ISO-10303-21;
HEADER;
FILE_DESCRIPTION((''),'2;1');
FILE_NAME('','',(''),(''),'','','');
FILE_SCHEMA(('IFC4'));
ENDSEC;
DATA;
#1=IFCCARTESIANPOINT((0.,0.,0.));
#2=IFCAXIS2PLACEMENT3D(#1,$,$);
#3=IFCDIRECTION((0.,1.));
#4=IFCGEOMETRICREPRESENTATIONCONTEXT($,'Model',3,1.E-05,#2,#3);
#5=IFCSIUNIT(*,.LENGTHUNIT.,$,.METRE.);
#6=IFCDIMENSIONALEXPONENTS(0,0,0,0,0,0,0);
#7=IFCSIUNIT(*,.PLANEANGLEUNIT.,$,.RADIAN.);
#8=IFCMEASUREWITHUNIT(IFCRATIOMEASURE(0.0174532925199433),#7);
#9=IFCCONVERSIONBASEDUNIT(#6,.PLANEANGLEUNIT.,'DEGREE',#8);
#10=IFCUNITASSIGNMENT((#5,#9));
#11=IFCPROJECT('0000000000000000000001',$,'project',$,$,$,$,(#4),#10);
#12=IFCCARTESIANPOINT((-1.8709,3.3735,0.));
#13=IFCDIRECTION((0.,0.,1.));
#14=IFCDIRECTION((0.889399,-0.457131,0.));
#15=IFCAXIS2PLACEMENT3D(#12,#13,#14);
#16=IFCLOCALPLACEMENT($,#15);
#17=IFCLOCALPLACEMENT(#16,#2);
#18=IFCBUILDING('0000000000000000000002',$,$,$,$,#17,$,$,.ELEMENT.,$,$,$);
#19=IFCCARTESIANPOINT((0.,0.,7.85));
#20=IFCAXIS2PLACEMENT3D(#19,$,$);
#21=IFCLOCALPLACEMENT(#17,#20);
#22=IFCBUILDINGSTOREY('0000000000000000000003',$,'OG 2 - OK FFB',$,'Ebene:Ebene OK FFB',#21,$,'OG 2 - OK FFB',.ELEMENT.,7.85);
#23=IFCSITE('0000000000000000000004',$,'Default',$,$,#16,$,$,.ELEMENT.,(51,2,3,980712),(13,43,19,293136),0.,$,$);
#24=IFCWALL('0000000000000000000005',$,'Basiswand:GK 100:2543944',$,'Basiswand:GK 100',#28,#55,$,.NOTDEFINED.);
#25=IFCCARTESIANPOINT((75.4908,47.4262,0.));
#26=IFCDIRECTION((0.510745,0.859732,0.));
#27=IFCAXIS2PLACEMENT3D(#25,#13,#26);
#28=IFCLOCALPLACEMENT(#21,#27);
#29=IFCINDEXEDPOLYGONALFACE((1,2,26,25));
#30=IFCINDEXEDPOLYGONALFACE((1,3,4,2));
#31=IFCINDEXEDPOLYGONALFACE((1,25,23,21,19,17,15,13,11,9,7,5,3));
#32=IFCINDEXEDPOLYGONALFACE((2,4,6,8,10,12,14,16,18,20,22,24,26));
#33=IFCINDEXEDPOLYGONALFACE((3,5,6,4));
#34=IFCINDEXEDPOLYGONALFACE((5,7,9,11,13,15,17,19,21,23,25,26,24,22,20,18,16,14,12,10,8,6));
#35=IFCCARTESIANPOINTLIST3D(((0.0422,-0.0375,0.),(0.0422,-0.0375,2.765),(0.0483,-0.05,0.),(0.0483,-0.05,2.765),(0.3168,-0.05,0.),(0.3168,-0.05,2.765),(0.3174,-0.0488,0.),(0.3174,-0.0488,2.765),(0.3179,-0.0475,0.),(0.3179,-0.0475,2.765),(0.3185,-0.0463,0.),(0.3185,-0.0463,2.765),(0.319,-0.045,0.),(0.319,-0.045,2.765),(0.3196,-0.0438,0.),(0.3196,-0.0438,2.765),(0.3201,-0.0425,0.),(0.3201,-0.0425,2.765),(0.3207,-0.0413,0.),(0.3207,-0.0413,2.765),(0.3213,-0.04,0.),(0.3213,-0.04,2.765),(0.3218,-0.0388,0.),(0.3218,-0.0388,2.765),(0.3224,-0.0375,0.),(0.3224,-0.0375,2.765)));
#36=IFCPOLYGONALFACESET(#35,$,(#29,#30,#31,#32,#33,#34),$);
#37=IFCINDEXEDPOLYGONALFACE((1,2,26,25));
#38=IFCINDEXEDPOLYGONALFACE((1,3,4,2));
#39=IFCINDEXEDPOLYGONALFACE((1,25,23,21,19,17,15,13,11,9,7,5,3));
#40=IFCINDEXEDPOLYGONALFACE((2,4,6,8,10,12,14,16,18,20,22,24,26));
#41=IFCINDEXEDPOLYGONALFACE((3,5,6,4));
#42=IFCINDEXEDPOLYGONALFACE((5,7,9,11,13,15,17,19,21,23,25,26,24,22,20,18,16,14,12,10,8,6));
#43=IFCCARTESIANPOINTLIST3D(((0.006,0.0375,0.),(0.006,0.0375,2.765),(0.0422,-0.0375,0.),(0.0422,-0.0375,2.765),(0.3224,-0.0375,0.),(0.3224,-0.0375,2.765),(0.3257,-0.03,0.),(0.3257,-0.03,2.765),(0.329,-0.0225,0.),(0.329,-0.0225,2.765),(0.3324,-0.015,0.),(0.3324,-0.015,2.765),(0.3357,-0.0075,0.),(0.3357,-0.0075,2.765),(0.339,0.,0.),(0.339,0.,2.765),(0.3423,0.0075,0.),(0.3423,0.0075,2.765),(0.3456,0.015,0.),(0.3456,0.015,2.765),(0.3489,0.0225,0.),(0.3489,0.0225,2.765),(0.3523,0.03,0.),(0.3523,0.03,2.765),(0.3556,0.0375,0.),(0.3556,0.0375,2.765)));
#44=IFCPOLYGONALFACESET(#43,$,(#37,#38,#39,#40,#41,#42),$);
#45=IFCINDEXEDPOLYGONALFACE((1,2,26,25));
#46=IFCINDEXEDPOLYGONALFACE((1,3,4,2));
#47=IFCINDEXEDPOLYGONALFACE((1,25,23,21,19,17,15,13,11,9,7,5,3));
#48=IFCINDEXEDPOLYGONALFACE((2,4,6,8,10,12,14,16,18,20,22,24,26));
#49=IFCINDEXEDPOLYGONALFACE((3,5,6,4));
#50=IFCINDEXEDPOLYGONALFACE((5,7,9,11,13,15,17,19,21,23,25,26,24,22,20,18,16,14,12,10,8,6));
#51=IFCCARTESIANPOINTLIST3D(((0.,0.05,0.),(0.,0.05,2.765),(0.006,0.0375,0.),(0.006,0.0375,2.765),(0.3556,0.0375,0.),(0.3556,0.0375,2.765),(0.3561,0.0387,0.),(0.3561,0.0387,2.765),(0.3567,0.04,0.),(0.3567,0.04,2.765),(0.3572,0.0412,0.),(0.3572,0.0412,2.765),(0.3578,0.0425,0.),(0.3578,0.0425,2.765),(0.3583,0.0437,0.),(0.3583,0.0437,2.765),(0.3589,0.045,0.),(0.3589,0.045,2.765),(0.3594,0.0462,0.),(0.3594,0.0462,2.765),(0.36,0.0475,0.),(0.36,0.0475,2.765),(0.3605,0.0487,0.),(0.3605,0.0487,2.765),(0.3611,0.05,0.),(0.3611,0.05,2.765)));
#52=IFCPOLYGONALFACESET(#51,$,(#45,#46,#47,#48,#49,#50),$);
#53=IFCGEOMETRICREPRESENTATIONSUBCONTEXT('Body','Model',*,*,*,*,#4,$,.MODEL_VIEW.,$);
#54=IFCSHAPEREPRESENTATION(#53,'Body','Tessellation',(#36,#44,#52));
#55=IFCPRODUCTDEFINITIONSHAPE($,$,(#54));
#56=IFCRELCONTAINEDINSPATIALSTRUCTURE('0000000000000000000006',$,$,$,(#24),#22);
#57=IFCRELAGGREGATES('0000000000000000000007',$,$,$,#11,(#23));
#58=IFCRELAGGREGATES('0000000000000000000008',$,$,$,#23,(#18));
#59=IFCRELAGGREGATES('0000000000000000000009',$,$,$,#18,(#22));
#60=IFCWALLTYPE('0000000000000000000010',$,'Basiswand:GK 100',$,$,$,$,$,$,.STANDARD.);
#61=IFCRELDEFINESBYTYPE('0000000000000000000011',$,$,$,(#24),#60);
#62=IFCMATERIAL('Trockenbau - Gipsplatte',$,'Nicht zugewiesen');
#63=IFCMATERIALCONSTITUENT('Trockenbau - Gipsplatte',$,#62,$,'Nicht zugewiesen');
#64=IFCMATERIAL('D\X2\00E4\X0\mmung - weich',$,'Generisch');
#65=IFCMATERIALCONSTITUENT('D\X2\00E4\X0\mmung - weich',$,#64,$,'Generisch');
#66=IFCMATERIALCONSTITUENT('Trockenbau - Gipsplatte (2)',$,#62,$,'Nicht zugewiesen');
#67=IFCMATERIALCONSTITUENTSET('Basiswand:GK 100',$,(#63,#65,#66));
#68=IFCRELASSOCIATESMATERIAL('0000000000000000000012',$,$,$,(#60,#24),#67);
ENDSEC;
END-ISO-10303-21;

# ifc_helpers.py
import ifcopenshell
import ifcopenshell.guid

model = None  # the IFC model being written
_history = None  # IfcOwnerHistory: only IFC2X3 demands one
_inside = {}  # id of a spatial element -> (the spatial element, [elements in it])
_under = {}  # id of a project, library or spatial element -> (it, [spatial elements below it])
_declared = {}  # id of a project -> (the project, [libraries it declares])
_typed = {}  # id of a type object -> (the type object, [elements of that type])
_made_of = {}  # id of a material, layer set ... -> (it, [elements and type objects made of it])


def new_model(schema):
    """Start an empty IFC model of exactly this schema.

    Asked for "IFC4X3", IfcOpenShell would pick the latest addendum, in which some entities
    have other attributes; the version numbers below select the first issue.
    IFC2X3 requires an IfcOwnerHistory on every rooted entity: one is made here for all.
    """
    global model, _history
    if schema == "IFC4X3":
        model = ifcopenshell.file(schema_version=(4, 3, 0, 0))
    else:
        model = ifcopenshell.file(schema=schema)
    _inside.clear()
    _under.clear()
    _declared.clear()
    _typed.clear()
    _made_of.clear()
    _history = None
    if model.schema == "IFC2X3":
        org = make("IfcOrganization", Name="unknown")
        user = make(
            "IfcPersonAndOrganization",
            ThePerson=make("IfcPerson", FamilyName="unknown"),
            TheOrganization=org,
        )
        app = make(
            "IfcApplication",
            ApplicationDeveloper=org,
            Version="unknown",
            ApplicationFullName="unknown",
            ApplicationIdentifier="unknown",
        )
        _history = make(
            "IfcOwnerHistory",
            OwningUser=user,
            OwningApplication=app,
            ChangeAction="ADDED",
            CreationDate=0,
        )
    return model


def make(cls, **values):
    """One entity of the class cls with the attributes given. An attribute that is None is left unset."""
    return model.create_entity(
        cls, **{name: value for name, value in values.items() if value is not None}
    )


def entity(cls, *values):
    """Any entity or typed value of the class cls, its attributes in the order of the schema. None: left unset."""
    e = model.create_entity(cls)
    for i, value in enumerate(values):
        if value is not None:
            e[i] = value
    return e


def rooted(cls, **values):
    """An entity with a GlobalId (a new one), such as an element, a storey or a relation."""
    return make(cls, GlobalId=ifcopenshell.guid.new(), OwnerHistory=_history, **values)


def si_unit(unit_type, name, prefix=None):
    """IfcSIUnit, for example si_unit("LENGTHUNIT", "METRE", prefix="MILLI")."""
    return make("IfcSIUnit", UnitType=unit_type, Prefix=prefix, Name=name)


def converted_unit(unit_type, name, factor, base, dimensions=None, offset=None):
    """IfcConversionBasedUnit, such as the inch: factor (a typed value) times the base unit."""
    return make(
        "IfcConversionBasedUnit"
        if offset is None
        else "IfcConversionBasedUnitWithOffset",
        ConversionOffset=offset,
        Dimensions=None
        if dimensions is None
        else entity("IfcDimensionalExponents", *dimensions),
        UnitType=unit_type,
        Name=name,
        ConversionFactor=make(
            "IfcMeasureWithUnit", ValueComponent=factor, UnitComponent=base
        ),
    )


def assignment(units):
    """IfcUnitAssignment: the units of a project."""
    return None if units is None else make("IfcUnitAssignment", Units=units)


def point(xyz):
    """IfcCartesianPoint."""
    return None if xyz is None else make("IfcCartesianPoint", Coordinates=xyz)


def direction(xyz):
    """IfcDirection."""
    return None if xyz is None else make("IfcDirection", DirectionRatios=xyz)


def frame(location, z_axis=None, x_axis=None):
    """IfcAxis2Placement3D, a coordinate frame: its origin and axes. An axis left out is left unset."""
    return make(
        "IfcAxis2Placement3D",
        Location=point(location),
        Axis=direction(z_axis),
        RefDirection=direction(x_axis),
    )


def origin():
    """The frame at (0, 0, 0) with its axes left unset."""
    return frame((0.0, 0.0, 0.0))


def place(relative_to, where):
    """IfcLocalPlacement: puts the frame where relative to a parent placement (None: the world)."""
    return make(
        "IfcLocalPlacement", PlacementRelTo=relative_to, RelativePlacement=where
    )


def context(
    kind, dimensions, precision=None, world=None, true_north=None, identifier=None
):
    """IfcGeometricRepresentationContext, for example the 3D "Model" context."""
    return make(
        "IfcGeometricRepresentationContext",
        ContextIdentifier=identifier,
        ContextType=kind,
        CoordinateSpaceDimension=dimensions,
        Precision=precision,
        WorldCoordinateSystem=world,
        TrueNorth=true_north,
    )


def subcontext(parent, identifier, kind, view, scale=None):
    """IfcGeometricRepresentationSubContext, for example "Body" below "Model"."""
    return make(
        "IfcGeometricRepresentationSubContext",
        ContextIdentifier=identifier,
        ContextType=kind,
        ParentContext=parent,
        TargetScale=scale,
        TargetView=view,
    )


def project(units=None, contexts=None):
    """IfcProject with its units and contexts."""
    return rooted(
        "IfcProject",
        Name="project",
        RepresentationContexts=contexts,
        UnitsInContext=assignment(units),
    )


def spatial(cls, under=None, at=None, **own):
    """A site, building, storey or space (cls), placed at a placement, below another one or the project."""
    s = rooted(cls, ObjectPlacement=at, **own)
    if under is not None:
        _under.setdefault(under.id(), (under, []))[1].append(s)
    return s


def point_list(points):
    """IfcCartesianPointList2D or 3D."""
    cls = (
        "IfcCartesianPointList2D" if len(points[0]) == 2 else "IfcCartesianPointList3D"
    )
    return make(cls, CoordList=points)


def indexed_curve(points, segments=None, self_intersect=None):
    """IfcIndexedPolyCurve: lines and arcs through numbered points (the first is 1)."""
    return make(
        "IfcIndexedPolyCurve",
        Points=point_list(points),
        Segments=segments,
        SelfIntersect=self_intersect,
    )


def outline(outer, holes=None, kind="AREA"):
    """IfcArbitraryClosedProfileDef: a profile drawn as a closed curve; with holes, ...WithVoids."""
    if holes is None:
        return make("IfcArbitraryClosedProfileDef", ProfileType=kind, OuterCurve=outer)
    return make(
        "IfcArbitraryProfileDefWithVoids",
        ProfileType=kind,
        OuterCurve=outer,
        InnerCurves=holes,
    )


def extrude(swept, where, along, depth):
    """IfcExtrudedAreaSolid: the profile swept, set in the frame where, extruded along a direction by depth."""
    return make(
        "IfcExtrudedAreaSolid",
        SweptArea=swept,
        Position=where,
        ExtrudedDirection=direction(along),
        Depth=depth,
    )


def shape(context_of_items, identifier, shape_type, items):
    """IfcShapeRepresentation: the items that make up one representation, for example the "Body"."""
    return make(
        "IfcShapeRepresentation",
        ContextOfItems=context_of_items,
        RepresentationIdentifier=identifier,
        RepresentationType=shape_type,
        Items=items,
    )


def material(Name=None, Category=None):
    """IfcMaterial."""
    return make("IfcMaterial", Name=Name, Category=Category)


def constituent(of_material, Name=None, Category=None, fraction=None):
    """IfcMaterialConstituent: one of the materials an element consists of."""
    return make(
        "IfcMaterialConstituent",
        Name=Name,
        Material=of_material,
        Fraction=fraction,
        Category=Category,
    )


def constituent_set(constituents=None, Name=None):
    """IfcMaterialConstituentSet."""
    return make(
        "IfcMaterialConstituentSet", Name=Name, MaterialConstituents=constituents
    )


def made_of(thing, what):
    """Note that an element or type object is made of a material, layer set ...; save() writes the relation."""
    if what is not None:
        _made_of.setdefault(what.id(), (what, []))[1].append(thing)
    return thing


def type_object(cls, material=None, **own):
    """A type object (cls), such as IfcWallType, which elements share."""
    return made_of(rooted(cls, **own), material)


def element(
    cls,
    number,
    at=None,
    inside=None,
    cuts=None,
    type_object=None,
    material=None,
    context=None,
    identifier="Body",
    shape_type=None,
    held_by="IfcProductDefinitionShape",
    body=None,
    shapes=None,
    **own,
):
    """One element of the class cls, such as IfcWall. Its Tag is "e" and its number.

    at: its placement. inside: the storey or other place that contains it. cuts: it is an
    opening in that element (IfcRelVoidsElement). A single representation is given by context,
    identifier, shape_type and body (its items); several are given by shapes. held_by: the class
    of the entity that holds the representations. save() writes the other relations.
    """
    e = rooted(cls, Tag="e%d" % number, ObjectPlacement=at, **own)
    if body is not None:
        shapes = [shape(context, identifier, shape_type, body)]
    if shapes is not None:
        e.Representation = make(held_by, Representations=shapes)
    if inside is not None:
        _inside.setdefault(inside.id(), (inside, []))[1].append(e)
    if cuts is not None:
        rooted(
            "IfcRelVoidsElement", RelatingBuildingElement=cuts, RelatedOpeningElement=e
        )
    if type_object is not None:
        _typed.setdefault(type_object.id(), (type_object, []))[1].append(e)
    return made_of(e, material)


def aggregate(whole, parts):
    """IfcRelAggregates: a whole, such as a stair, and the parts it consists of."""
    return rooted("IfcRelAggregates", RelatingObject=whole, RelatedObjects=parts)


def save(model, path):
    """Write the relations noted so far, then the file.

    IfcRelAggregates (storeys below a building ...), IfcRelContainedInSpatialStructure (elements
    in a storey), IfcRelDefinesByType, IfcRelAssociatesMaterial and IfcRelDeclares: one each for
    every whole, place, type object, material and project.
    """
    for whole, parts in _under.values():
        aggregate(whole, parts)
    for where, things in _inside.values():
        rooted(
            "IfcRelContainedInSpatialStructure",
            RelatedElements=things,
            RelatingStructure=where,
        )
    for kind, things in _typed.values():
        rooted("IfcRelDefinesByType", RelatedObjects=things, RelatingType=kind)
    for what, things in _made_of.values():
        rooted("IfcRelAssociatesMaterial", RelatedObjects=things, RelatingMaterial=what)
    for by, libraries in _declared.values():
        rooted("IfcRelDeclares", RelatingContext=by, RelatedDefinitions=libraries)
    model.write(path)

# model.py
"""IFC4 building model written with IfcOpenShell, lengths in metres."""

from ifc_helpers import new_model, entity, si_unit, converted_unit, direction, frame, origin, place, context, subcontext, project, spatial, indexed_curve, outline, extrude, material, constituent, constituent_set, type_object, element, save


model = new_model("IFC4")

# Units and contexts
model_context = context("Model", 3, precision=1e-05, world=origin(), true_north=direction((0.0, 1.0)))
body_context = subcontext(model_context, "Body", "Model", "MODEL_VIEW")
ifc_project = project(units=[si_unit("LENGTHUNIT", "METRE"), converted_unit("PLANEANGLEUNIT", "DEGREE", entity("IfcRatioMeasure", 0.0174532925199433), si_unit("PLANEANGLEUNIT", "RADIAN"), dimensions=[0, 0, 0, 0, 0, 0, 0])], contexts=[model_context])

# Site, building, storey
site_placement = place(None, frame((-1.8709, 3.3735, 0.0), z_axis=(0.0, 0.0, 1.0), x_axis=(0.889399, -0.457131, 0.0)))
site = spatial("IfcSite", under=ifc_project, at=site_placement, Name="Default", CompositionType="ELEMENT", RefLatitude=(51, 2, 3, 980712), RefLongitude=(13, 43, 19, 293136), RefElevation=0.0)
building_placement = place(site_placement, origin())
building = spatial("IfcBuilding", under=site, at=building_placement, CompositionType="ELEMENT")
storey_placement = place(building_placement, frame((0.0, 0.0, 7.85)))
storey = spatial("IfcBuildingStorey", under=building, at=storey_placement, Name="OG 2 - OK FFB", ObjectType="Ebene:Ebene OK FFB", LongName="OG 2 - OK FFB", CompositionType="ELEMENT", Elevation=7.85)

# Shared definitions
ifc_material_1 = material(Name="Trockenbau - Gipsplatte", Category="Nicht zugewiesen")
ifc_constituent_1 = constituent(ifc_material_1, Name="Trockenbau - Gipsplatte", Category="Nicht zugewiesen")
ifc_material_2 = material(Name="Dämmung - weich", Category="Generisch")
ifc_constituent_2 = constituent(ifc_material_2, Name="Dämmung - weich", Category="Generisch")
ifc_constituent_3 = constituent(ifc_material_1, Name="Trockenbau - Gipsplatte (2)", Category="Nicht zugewiesen")
ifc_constituent_set_1 = constituent_set(constituents=[ifc_constituent_1, ifc_constituent_2, ifc_constituent_3], Name="Basiswand:GK 100")
wall_type_1 = type_object("IfcWallType", Name="Basiswand:GK 100", PredefinedType="STANDARD", material=ifc_constituent_set_1)

# Wall
wall_1_placement = place(storey_placement, frame((75.4908, 47.4262, 0.0), z_axis=(0.0, 0.0, 1.0), x_axis=(0.510745, 0.859732, 0.0)))
element("IfcWall", 1, at=wall_1_placement, inside=storey, type_object=wall_type_1, material=ifc_constituent_set_1, Name="Basiswand:GK 100:2543944", ObjectType="Basiswand:GK 100", PredefinedType="NOTDEFINED", context=body_context, shape_type="SweptSolid", body=[
    extrude(outline(indexed_curve([(0.049, -0.1253), (0.0504, -0.1253), (0.0517, -0.1253), (0.0531, -0.1253), (0.0545, -0.1253), (0.0558, -0.1253), (0.0572, -0.1253), (0.0586, -0.1253), (0.0599, -0.1253), (0.0613, -0.1253), (0.0627, -0.1253), (-0.0514, 0.1306), (-0.0603, 0.12), (0.049, -0.1253)], self_intersect=False)), frame((0.1824, -0.0437, 0.0), z_axis=(0.0, 0.0, 1.0), x_axis=(0.407029, 0.913415, 0.0)), (0.0, 0.0, 1.0), 2.765),
    extrude(outline(indexed_curve([(-0.1393, -0.0375), (0.1408, -0.0375), (0.1442, -0.03), (0.1475, -0.0225), (0.1508, -0.015), (0.1541, -0.0075), (0.1575, 0.0), (0.1608, 0.0075), (0.1641, 0.015), (0.1674, 0.0225), (0.1707, 0.03), (0.174, 0.0375), (-0.1755, 0.0375), (-0.1393, -0.0375)], self_intersect=False)), frame((0.1815, 0.0, 0.0)), (0.0, 0.0, 1.0), 2.765),
    extrude(outline(indexed_curve([(-0.0841, -0.16), (-0.0703, -0.16), (0.0816, 0.1548), (0.0808, 0.1558), (0.0799, 0.1569), (0.079, 0.1579), (0.0781, 0.159), (0.0772, 0.16), (0.0763, 0.161), (0.0754, 0.1621), (0.0745, 0.1631), (0.0737, 0.1641), (0.0728, 0.1652), (-0.0841, -0.16)], self_intersect=False)), frame((0.1807, 0.0437, 0.0), z_axis=(0.0, 0.0, 1.0), x_axis=(0.434605, -0.900621, 0.0)), (0.0, 0.0, 1.0), 2.765),
])

save(model, "model.ifc")
